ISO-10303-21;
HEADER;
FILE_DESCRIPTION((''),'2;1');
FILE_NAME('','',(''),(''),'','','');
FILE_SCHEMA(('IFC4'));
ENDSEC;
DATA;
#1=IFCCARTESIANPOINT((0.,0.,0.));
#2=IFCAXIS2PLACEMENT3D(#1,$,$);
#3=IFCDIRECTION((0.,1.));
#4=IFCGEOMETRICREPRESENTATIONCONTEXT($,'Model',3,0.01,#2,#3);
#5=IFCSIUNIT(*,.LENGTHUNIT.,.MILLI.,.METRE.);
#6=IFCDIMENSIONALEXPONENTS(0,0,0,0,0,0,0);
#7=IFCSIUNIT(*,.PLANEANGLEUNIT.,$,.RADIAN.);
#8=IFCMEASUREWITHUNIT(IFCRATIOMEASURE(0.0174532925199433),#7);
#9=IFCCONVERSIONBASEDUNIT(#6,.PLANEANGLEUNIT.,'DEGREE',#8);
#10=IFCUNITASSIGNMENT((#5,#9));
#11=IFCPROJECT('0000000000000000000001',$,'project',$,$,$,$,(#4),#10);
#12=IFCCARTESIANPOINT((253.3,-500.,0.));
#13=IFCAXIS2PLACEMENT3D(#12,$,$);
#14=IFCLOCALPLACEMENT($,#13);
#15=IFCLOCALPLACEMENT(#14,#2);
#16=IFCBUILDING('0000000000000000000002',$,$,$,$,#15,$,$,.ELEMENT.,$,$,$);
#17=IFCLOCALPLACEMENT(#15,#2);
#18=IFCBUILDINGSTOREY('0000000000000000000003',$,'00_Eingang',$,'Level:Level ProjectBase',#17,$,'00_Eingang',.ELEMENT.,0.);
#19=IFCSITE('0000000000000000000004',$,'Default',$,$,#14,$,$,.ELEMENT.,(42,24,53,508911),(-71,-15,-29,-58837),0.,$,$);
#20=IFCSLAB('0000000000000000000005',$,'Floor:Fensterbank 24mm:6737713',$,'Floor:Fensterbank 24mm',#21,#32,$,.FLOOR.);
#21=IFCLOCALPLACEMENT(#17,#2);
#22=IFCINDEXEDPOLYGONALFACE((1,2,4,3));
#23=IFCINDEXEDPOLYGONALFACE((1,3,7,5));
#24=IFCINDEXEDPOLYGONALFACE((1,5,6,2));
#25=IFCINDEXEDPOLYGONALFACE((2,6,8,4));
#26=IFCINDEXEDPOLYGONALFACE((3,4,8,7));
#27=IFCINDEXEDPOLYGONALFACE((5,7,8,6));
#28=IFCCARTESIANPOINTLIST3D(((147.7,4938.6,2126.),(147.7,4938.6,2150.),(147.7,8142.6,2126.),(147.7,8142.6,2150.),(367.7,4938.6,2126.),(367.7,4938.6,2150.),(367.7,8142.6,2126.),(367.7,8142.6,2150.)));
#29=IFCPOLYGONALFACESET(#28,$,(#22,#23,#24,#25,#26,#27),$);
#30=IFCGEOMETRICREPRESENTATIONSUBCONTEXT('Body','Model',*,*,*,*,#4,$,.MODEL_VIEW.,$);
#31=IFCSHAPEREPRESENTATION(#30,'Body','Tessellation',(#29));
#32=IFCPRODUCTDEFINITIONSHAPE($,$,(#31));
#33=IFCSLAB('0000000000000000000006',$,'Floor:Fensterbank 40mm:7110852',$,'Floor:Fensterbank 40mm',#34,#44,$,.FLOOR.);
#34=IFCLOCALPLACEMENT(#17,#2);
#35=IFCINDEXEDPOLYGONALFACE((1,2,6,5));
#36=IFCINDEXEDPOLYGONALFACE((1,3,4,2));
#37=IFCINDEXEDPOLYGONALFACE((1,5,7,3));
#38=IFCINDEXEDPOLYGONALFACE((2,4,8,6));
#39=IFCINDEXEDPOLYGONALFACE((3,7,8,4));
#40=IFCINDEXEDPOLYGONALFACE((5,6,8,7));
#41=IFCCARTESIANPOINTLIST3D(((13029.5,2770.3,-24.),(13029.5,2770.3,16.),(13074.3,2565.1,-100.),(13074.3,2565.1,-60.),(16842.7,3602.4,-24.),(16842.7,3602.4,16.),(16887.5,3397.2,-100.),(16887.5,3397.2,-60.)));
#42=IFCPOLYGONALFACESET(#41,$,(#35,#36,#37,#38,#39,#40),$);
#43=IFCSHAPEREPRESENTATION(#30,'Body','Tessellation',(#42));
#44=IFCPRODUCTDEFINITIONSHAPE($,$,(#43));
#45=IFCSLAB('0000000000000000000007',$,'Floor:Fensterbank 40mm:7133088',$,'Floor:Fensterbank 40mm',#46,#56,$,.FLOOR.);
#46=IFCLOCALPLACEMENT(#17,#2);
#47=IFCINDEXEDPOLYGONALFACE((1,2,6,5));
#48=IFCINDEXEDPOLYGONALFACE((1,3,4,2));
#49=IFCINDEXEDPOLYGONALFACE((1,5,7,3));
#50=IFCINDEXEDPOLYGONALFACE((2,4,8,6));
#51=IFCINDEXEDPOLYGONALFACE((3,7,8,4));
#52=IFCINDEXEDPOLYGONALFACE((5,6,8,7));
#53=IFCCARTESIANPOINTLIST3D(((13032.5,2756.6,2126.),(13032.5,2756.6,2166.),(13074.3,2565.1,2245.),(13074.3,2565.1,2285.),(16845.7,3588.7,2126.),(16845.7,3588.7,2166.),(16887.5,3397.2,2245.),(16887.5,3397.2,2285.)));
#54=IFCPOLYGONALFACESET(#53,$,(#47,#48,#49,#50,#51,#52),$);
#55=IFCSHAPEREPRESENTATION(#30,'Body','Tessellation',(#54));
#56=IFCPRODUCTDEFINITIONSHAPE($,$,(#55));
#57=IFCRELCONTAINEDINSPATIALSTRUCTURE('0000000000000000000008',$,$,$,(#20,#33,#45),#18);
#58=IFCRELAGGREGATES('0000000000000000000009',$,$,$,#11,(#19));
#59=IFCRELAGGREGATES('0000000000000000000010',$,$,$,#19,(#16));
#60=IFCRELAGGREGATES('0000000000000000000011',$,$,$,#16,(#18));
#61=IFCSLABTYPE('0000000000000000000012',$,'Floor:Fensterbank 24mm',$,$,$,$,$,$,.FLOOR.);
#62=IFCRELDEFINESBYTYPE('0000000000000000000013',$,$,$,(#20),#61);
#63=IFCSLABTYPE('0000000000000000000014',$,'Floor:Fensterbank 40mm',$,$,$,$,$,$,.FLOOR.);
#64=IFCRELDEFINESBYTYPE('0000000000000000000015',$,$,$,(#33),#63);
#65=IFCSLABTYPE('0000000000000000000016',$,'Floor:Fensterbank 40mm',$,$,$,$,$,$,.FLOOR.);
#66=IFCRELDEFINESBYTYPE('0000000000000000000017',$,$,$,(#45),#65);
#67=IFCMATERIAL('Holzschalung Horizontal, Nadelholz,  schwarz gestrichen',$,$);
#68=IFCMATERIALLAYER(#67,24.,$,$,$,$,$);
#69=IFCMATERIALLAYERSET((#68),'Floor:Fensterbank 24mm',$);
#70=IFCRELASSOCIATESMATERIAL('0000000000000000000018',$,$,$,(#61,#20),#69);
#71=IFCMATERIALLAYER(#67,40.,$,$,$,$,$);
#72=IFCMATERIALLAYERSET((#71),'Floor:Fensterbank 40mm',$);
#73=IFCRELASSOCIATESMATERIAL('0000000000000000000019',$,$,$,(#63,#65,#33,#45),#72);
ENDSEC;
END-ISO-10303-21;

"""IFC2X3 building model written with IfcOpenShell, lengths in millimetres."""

from ifc_helpers import new_model, entity, si_unit, converted_unit, direction, frame, frame_2d, origin, place, context, subcontext, project, spatial, polyline, rectangle, outline, extrude, clip, halfspace, material, layer, layer_set, layer_usage, type_object, element, save


model = new_model("IFC2X3")

# Units and contexts
model_context = context("Model", 3, precision=0.01, world=origin(), true_north=direction((0.0, 1.0)))
body_context = subcontext(model_context, "Body", "Model", "MODEL_VIEW")
ifc_project = project(units=[si_unit("LENGTHUNIT", "METRE", prefix="MILLI"), converted_unit("PLANEANGLEUNIT", "DEGREE", entity("IfcRatioMeasure", 0.0174532925199433), si_unit("PLANEANGLEUNIT", "RADIAN"), dimensions=[0, 0, 0, 0, 0, 0, 0])], contexts=[model_context])

# Site, building, storey
site_placement = place(None, frame((253.3, -500.0, 0.0)))
site = spatial("IfcSite", under=ifc_project, at=site_placement, Name="Default", CompositionType="ELEMENT", RefLatitude=(42, 24, 53, 508911), RefLongitude=(-71, -15, -29, -58837), RefElevation=0.0)
building_placement = place(site_placement, origin())
building = spatial("IfcBuilding", under=site, at=building_placement, CompositionType="ELEMENT")
storey_placement = place(building_placement, origin())
storey = spatial("IfcBuildingStorey", under=building, at=storey_placement, Name="00_Eingang", ObjectType="Level:Level ProjectBase", LongName="00_Eingang", CompositionType="ELEMENT", Elevation=0.0)

# Slabs
ifc_material_1 = material(Name="Holzschalung Horizontal, Nadelholz,  schwarz gestrichen")
ifc_layer_1 = layer(ifc_material_1, 24.0)
ifc_layer_set_1 = layer_set([ifc_layer_1], Name="Floor:Fensterbank 24mm")
ifc_layer_usage_1 = layer_usage(ifc_layer_set_1, "AXIS3", "POSITIVE", 0.0)
slab_type_1 = type_object("IfcSlabType", Name="Floor:Fensterbank 24mm", PredefinedType="FLOOR", material=ifc_layer_set_1)
slab_1_placement = place(storey_placement, origin())
element("IfcSlab", 1, at=slab_1_placement, inside=storey, type_object=slab_type_1, material=ifc_layer_usage_1, Name="Floor:Fensterbank 24mm:6737713", ObjectType="Floor:Fensterbank 24mm", PredefinedType="FLOOR", context=body_context, shape_type="SweptSolid", body=[
    extrude(rectangle(XDim=3204.0, YDim=220.0, at=frame_2d((0.0, 0.0), x_axis=(1.0, 0.0))), frame((257.7, 6540.6, 2150.0), z_axis=(0.0, 0.0, -1.0), x_axis=(0.0, 1.0, 0.0)), (0.0, 0.0, 1.0), 24.0),
])
ifc_layer_2 = layer(ifc_material_1, 40.0)
ifc_layer_set_2 = layer_set([ifc_layer_2], Name="Floor:Fensterbank 40mm")
ifc_layer_usage_2 = layer_usage(ifc_layer_set_2, "AXIS3", "POSITIVE", 0.0)
slab_type_2 = type_object("IfcSlabType", Name="Floor:Fensterbank 40mm", PredefinedType="FLOOR", material=ifc_layer_set_2)
slab_2_placement = place(storey_placement, origin())
element("IfcSlab", 2, at=slab_2_placement, inside=storey, type_object=slab_type_2, material=ifc_layer_usage_2, Name="Floor:Fensterbank 40mm:7110852", ObjectType="Floor:Fensterbank 40mm", PredefinedType="FLOOR", context=body_context, shape_type="Clipping", body=[
    clip(clip(extrude(outline(polyline([(-1951.5, -111.7), (1951.5, -111.7), (1951.5, 111.7), (-1951.5, 111.7), (-1951.5, -111.7)])), frame((14958.5, 3083.8, -22.0), z_axis=(-0.072553, 0.33248, -0.940315), x_axis=(0.977008, 0.213201, 0.0)), (0.0, 0.340305, 0.940315), 42.5), halfspace(frame((14958.5, 3083.8, -62.0), z_axis=(-0.072553, 0.33248, -0.940315), x_axis=(0.977008, 0.213201, 0.0)), False)), halfspace(frame((14958.5, 3083.8, -22.0), z_axis=(0.072553, -0.33248, 0.940315), x_axis=(0.977008, 0.213201, 0.0)), False)),
])
ifc_layer_usage_3 = layer_usage(ifc_layer_set_2, "AXIS3", "POSITIVE", 0.0)
slab_type_3 = type_object("IfcSlabType", Name="Floor:Fensterbank 40mm", PredefinedType="FLOOR", material=ifc_layer_set_2)
slab_3_placement = place(storey_placement, origin())
element("IfcSlab", 3, at=slab_3_placement, inside=storey, type_object=slab_type_3, material=ifc_layer_usage_3, Name="Floor:Fensterbank 40mm:7133088", ObjectType="Floor:Fensterbank 40mm", PredefinedType="FLOOR", context=body_context, shape_type="Clipping", body=[
    clip(clip(extrude(rectangle(XDim=229.3, YDim=3902.9, at=frame_2d((0.0, 0.0), x_axis=(0.0, 1.0))), frame((14960.0, 3076.9, 2225.5), z_axis=(0.110647, -0.507046, -0.854787), x_axis=(0.977008, 0.213201, 0.0)), (0.0, -0.518979, 0.854787), 46.8), halfspace(frame((14960.0, 3076.9, 2185.5), z_axis=(0.110647, -0.507046, -0.854787), x_axis=(-0.977008, -0.213201, 0.0)), False)), halfspace(frame((14960.0, 3076.9, 2225.5), z_axis=(-0.110647, 0.507046, 0.854787), x_axis=(-0.977008, -0.213201, 0.0)), False)),
])

save(model, "model.ifc")
